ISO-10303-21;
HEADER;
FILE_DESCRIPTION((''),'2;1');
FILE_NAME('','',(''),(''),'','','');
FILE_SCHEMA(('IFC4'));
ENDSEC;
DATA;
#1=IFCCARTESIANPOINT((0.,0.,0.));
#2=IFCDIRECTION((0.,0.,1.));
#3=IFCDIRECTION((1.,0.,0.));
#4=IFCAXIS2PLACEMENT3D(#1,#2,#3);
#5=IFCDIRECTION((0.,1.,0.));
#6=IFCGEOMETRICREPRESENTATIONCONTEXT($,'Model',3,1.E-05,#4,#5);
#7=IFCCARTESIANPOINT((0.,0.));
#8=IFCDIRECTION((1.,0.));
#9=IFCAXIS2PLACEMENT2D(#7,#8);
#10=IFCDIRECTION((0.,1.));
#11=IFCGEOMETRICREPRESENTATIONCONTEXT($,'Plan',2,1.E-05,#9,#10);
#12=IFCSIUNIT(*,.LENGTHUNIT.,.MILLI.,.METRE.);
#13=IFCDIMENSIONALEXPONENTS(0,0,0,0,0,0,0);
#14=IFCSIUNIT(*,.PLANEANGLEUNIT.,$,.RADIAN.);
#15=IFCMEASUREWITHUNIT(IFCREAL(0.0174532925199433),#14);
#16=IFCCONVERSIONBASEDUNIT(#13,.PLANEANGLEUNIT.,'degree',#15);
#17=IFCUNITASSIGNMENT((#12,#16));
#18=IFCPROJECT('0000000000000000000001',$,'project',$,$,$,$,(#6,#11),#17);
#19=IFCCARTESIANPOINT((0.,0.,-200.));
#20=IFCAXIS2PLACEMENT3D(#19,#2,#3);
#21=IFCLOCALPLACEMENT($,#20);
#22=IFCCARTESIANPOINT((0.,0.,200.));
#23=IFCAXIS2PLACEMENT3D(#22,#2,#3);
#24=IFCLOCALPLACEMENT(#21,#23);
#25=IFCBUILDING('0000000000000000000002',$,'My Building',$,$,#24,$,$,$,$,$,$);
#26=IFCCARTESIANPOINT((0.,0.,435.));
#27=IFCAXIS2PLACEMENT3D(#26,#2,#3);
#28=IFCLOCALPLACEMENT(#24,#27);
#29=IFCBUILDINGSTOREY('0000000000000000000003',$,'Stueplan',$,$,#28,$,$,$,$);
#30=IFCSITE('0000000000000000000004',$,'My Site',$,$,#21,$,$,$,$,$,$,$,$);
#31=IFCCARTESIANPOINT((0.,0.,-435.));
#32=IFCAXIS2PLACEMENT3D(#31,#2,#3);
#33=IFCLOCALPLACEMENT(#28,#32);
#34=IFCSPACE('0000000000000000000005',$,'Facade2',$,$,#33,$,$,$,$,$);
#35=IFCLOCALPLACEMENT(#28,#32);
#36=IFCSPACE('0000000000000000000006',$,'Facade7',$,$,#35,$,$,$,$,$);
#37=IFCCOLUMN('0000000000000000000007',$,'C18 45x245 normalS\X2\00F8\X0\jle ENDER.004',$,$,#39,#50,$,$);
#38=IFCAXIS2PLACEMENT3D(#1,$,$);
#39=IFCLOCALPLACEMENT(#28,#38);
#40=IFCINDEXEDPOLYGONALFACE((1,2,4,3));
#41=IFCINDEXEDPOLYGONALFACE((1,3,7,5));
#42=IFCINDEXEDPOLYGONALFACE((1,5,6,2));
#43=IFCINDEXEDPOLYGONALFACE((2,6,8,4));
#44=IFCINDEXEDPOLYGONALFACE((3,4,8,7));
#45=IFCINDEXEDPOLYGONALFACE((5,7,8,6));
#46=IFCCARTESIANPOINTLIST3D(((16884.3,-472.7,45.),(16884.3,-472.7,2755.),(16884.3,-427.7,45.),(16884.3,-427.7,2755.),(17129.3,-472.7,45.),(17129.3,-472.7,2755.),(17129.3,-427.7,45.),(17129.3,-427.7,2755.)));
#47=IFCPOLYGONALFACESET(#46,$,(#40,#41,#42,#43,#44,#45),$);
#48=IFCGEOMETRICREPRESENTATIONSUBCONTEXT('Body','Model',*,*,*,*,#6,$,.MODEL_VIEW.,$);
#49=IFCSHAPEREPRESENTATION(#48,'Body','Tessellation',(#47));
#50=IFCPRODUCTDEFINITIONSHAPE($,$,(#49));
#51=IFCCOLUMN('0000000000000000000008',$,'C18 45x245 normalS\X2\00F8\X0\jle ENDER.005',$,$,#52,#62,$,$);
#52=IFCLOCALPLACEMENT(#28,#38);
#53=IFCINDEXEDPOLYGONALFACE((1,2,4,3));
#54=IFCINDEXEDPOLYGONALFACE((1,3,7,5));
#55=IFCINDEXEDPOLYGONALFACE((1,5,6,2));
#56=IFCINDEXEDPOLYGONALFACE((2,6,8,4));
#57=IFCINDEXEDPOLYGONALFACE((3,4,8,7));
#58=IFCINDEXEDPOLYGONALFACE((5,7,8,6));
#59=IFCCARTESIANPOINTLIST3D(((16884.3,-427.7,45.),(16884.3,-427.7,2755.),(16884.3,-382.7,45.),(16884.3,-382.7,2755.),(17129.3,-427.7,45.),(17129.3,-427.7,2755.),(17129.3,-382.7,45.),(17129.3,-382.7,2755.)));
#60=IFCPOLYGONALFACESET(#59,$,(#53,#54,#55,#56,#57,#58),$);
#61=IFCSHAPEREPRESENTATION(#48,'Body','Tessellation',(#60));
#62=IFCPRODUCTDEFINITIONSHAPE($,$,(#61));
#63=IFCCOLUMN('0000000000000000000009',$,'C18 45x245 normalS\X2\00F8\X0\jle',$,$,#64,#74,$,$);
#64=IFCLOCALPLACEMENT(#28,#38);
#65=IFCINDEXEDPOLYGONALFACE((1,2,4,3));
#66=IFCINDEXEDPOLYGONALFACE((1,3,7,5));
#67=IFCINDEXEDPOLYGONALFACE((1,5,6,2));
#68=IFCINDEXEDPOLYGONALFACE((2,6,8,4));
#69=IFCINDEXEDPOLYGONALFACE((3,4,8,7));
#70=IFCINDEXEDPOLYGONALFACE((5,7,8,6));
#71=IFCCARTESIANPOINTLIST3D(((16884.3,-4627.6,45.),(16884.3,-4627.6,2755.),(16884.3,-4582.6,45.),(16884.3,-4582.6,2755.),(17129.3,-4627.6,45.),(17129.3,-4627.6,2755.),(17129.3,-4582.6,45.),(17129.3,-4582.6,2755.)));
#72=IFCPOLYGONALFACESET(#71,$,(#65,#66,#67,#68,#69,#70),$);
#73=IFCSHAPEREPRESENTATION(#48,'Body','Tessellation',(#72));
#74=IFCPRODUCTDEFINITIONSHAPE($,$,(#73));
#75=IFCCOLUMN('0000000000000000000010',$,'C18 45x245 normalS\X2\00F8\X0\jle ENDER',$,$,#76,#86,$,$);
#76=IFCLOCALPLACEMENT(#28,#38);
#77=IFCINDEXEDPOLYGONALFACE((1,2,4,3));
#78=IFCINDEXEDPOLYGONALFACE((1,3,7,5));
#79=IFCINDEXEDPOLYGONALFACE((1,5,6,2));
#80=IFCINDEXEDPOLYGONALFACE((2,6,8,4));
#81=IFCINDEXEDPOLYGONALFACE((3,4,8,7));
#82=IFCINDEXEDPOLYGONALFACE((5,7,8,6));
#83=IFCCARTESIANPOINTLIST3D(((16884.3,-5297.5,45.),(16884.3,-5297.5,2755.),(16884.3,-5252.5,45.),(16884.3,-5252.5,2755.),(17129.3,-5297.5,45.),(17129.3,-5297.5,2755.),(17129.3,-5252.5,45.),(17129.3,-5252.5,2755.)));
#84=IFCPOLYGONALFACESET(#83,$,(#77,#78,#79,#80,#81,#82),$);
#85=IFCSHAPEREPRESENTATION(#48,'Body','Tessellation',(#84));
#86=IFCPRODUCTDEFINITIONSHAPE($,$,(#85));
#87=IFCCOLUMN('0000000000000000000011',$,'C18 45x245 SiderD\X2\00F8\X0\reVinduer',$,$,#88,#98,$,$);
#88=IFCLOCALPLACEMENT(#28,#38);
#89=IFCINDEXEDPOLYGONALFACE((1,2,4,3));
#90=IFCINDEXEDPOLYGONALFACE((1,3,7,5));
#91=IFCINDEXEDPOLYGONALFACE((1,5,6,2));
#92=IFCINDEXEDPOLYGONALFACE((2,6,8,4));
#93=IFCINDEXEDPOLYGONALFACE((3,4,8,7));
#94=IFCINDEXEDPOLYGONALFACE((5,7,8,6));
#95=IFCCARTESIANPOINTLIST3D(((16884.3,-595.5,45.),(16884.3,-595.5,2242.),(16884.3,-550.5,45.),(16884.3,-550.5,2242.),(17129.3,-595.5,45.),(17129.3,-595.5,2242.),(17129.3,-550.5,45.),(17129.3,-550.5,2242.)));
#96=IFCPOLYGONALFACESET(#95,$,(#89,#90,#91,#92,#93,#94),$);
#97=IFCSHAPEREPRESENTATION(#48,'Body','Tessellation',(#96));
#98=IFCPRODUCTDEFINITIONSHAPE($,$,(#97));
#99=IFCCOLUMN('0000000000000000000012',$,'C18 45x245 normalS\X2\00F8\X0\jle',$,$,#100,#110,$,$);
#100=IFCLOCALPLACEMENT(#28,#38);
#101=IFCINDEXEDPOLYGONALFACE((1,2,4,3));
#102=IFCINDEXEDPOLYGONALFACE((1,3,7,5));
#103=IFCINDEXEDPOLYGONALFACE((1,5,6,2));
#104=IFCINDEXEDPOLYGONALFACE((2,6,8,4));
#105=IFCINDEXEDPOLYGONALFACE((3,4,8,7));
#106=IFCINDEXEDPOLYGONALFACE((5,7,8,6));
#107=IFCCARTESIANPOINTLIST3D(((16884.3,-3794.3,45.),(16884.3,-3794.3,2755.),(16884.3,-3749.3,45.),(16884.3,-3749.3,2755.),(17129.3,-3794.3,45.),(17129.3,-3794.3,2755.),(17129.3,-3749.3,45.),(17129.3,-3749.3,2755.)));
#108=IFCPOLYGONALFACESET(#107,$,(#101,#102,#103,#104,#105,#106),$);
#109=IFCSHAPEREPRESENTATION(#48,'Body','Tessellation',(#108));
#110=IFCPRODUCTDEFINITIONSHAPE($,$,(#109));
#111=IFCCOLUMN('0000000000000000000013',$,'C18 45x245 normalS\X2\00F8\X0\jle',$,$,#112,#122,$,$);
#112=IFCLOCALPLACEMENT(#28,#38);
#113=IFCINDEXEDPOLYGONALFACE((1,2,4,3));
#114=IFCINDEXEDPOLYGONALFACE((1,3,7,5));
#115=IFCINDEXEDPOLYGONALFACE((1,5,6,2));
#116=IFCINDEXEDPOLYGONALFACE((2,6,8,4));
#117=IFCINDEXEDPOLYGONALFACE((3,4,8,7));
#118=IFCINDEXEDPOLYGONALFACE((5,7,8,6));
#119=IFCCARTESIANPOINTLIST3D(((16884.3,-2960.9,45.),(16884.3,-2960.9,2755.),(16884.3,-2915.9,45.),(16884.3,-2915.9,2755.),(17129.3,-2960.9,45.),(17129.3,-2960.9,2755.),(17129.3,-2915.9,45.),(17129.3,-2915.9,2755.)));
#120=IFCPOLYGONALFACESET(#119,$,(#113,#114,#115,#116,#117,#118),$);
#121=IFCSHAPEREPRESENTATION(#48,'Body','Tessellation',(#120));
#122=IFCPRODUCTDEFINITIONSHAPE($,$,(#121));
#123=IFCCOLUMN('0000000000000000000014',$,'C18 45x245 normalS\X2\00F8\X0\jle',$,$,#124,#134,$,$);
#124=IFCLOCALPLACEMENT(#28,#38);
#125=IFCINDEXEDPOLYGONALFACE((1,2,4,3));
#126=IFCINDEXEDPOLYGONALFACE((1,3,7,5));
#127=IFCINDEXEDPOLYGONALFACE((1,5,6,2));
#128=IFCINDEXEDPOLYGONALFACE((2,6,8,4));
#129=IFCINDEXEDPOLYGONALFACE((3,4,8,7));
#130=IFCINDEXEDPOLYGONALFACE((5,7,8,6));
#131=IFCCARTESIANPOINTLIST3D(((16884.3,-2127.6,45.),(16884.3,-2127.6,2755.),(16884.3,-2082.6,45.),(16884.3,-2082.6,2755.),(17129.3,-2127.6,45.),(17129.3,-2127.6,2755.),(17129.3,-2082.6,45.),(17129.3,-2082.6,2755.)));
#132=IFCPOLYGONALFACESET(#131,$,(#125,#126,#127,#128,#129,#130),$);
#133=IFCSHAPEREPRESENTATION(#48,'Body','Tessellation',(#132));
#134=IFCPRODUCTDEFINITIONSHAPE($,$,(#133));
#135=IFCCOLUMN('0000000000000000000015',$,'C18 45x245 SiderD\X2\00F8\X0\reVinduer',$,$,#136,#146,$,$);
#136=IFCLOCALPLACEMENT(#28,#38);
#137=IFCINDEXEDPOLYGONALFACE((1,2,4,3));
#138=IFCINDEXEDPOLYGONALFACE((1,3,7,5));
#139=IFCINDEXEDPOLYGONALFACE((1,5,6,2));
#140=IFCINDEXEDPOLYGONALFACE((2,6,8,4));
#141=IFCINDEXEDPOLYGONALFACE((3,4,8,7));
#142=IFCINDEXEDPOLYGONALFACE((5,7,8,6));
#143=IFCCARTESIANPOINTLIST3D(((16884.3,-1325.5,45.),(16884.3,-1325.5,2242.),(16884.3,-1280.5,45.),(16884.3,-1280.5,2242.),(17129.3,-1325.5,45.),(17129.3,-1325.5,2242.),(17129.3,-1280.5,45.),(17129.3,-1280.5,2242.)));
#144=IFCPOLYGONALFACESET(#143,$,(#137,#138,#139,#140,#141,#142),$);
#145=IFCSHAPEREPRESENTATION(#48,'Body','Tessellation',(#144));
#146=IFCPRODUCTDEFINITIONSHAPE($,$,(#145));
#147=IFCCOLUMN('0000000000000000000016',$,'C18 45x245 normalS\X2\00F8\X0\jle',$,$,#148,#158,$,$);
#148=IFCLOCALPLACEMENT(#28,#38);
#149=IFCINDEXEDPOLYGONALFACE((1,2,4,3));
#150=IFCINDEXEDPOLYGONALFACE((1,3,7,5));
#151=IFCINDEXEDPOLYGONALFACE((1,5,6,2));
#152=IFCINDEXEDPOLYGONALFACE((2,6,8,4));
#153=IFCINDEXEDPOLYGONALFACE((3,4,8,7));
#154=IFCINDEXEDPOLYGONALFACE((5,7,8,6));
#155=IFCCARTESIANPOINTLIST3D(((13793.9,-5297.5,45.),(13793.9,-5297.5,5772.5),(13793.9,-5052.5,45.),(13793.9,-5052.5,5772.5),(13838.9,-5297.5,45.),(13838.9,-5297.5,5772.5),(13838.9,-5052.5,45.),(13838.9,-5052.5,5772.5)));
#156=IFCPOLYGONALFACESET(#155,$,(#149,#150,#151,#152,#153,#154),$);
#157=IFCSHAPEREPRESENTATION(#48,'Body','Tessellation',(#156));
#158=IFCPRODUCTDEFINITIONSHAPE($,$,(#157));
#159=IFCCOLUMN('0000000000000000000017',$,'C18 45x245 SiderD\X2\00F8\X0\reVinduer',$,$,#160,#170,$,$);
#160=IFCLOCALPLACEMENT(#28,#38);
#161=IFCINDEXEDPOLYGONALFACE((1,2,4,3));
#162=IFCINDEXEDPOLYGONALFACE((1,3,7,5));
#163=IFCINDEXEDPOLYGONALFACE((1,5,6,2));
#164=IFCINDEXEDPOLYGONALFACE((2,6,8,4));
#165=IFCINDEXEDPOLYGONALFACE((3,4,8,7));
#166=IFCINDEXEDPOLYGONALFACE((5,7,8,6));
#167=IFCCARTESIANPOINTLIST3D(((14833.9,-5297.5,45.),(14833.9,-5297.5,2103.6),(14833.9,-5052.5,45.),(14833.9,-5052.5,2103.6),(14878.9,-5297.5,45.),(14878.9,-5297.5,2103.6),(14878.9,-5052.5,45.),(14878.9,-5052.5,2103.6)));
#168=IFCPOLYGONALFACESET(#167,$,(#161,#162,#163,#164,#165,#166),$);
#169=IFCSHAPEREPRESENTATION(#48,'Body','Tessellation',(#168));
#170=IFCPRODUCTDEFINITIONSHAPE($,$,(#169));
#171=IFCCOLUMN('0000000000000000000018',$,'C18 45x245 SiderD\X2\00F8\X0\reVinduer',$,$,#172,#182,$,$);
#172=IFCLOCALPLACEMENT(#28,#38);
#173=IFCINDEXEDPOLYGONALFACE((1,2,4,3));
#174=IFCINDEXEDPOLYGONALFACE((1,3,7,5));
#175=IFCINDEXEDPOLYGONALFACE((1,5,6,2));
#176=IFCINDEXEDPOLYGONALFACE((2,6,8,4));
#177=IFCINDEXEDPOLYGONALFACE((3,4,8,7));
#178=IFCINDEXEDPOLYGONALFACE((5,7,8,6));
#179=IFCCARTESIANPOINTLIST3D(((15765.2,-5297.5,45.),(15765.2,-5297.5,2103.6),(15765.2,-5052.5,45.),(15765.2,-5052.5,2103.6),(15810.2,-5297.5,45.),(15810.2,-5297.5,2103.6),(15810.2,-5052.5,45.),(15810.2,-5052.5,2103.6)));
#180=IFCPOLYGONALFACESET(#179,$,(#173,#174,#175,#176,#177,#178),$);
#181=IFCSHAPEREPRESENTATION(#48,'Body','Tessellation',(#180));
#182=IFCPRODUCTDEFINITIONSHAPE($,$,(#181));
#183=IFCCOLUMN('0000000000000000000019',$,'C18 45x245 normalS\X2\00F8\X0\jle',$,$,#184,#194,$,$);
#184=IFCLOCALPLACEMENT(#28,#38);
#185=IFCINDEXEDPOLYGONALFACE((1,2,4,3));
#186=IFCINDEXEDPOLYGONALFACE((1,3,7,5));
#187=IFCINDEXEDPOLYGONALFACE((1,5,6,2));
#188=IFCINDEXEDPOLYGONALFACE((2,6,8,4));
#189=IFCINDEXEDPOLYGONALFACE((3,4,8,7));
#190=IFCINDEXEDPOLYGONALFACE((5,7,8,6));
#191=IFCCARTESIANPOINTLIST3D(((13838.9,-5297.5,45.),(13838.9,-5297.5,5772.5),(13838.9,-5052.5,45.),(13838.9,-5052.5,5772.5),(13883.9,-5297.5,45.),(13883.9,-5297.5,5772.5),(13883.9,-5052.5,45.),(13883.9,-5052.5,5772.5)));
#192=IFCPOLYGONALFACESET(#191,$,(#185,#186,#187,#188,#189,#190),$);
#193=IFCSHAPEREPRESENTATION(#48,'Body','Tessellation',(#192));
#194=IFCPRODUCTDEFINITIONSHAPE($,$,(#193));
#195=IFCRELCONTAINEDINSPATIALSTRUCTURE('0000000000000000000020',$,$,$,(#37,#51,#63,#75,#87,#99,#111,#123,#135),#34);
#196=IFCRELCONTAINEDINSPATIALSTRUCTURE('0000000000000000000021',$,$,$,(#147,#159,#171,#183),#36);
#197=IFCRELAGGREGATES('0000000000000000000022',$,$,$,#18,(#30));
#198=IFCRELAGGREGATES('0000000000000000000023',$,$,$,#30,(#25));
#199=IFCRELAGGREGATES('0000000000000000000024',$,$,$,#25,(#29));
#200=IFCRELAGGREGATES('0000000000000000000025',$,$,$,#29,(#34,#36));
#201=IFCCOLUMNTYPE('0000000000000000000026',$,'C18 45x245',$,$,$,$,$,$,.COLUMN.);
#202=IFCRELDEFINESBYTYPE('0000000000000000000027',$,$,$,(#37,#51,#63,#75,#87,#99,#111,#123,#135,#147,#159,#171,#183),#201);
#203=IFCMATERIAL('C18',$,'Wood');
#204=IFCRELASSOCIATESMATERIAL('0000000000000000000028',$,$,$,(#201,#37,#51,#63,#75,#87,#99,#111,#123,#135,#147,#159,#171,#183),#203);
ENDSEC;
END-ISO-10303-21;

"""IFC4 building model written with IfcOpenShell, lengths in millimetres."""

from ifc_helpers import new_model, entity, si_unit, converted_unit, direction, frame, origin_with_axes, origin_2d_with_axis, place, context, subcontext, project, spatial, rectangle, extrude, material, material_profile, profile_set, profile_usage, type_object, element, save


model = new_model("IFC4")

# Units and contexts
model_context = context("Model", 3, precision=1e-05, world=origin_with_axes(), true_north=direction((0.0, 1.0, 0.0)))
plan_context = context("Plan", 2, precision=1e-05, world=origin_2d_with_axis(), true_north=direction((0.0, 1.0)))
body_context_1 = subcontext(model_context, "Body", "Model", "MODEL_VIEW")
ifc_project = project(units=[si_unit("LENGTHUNIT", "METRE", prefix="MILLI"), converted_unit("PLANEANGLEUNIT", "degree", entity("IfcReal", 0.0174532925199433), si_unit("PLANEANGLEUNIT", "RADIAN"), dimensions=[0, 0, 0, 0, 0, 0, 0])], contexts=[model_context, plan_context])

# Site, building, storey, space
site_placement = place(None, frame((0.0, 0.0, -200.0), z_axis=(0.0, 0.0, 1.0), x_axis=(1.0, 0.0, 0.0)))
site = spatial("IfcSite", under=ifc_project, at=site_placement, Name="My Site")
building_placement = place(site_placement, frame((0.0, 0.0, 200.0), z_axis=(0.0, 0.0, 1.0), x_axis=(1.0, 0.0, 0.0)))
building = spatial("IfcBuilding", under=site, at=building_placement, Name="My Building")
storey_placement = place(building_placement, frame((0.0, 0.0, 435.0), z_axis=(0.0, 0.0, 1.0), x_axis=(1.0, 0.0, 0.0)))
storey = spatial("IfcBuildingStorey", under=building, at=storey_placement, Name="Stueplan")
space_1_placement = place(storey_placement, frame((0.0, 0.0, -435.0), z_axis=(0.0, 0.0, 1.0), x_axis=(1.0, 0.0, 0.0)))
space_1 = spatial("IfcSpace", under=storey, at=space_1_placement, Name="Facade2")

# Columns
ifc_material = material(Name="C18", Category="Wood")
ifc_material_profile_1 = material_profile(ifc_material, rectangle(XDim=45.0, YDim=245.0))
ifc_profile_set_1 = profile_set([ifc_material_profile_1], Name="woodStructural")
ifc_profile_usage_1 = profile_usage(ifc_profile_set_1, cardinal=9)
column_type = type_object("IfcColumnType", Name="C18 45x245", PredefinedType="COLUMN", material=ifc_profile_set_1)
column_1_placement = place(space_1_placement, frame((17129.3, -427.7, 480.0), z_axis=(0.0, 0.0, 1.0), x_axis=(0.0, -1.0, 0.0)))
element("IfcColumn", 1, at=column_1_placement, inside=space_1, type_object=column_type, material=ifc_profile_usage_1, Name="C18 45x245 normalSøjle ENDER.004", context=body_context_1, shape_type="SweptSolid", body=[
    extrude(rectangle(XDim=45.0, YDim=245.0), frame((22.5, -122.5, 0.0), z_axis=(0.0, 0.0, 1.0), x_axis=(1.0, 0.0, 0.0)), (0.0, 0.0, 1.0), 2710.0),
])
ifc_profile_usage_2 = profile_usage(ifc_profile_set_1, cardinal=9)
column_2_placement = place(space_1_placement, frame((17129.3, -382.7, 480.0), z_axis=(0.0, 0.0, 1.0), x_axis=(0.0, -1.0, 0.0)))
element("IfcColumn", 2, at=column_2_placement, inside=space_1, type_object=column_type, material=ifc_profile_usage_2, Name="C18 45x245 normalSøjle ENDER.005", context=body_context_1, shape_type="SweptSolid", body=[
    extrude(rectangle(XDim=45.0, YDim=245.0), frame((22.5, -122.5, 0.0), z_axis=(0.0, 0.0, 1.0), x_axis=(1.0, 0.0, 0.0)), (0.0, 0.0, 1.0), 2710.0),
])
ifc_profile_usage_3 = profile_usage(ifc_profile_set_1, cardinal=9)
column_3_placement = place(space_1_placement, frame((17129.3, -4582.6, 480.0), z_axis=(0.0, 0.0, 1.0), x_axis=(0.0, -1.0, 0.0)))
element("IfcColumn", 3, at=column_3_placement, inside=space_1, type_object=column_type, material=ifc_profile_usage_3, Name="C18 45x245 normalSøjle", context=body_context_1, shape_type="SweptSolid", body=[
    extrude(rectangle(XDim=45.0, YDim=245.0), frame((22.5, -122.5, 0.0), z_axis=(0.0, 0.0, 1.0), x_axis=(1.0, 0.0, 0.0)), (0.0, 0.0, 1.0), 2710.0),
])
ifc_profile_usage_4 = profile_usage(ifc_profile_set_1, cardinal=9)
column_4_placement = place(space_1_placement, frame((17129.3, -5252.5, 480.0), z_axis=(0.0, 0.0, 1.0), x_axis=(0.0, -1.0, 0.0)))
element("IfcColumn", 4, at=column_4_placement, inside=space_1, type_object=column_type, material=ifc_profile_usage_4, Name="C18 45x245 normalSøjle ENDER", context=body_context_1, shape_type="SweptSolid", body=[
    extrude(rectangle(XDim=45.0, YDim=245.0), frame((22.5, -122.5, 0.0), z_axis=(0.0, 0.0, 1.0), x_axis=(1.0, 0.0, 0.0)), (0.0, 0.0, 1.0), 2710.0),
])
ifc_profile_usage_5 = profile_usage(ifc_profile_set_1, cardinal=9)
column_5_placement = place(space_1_placement, frame((17129.3, -550.5, 480.0), z_axis=(0.0, 0.0, 1.0), x_axis=(0.0, -1.0, 0.0)))
element("IfcColumn", 5, at=column_5_placement, inside=space_1, type_object=column_type, material=ifc_profile_usage_5, Name="C18 45x245 SiderDøreVinduer", context=body_context_1, shape_type="SweptSolid", body=[
    extrude(rectangle(XDim=45.0, YDim=245.0), frame((22.5, -122.5, 0.0), z_axis=(0.0, 0.0, 1.0), x_axis=(1.0, 0.0, 0.0)), (0.0, 0.0, 1.0), 2197.0),
])
ifc_profile_usage_6 = profile_usage(ifc_profile_set_1, cardinal=9)
column_6_placement = place(space_1_placement, frame((17129.3, -3749.3, 480.0), z_axis=(0.0, 0.0, 1.0), x_axis=(0.0, -1.0, 0.0)))
element("IfcColumn", 6, at=column_6_placement, inside=space_1, type_object=column_type, material=ifc_profile_usage_6, Name="C18 45x245 normalSøjle", context=body_context_1, shape_type="SweptSolid", body=[
    extrude(rectangle(XDim=45.0, YDim=245.0), frame((22.5, -122.5, 0.0), z_axis=(0.0, 0.0, 1.0), x_axis=(1.0, 0.0, 0.0)), (0.0, 0.0, 1.0), 2710.0),
])
ifc_profile_usage_7 = profile_usage(ifc_profile_set_1, cardinal=9)
column_7_placement = place(space_1_placement, frame((17129.3, -2915.9, 480.0), z_axis=(0.0, 0.0, 1.0), x_axis=(0.0, -1.0, 0.0)))
element("IfcColumn", 7, at=column_7_placement, inside=space_1, type_object=column_type, material=ifc_profile_usage_7, Name="C18 45x245 normalSøjle", context=body_context_1, shape_type="SweptSolid", body=[
    extrude(rectangle(XDim=45.0, YDim=245.0), frame((22.5, -122.5, 0.0), z_axis=(0.0, 0.0, 1.0), x_axis=(1.0, 0.0, 0.0)), (0.0, 0.0, 1.0), 2710.0),
])
ifc_profile_usage_8 = profile_usage(ifc_profile_set_1, cardinal=9)
column_8_placement = place(space_1_placement, frame((17129.3, -2082.6, 480.0), z_axis=(0.0, 0.0, 1.0), x_axis=(0.0, -1.0, 0.0)))
element("IfcColumn", 8, at=column_8_placement, inside=space_1, type_object=column_type, material=ifc_profile_usage_8, Name="C18 45x245 normalSøjle", context=body_context_1, shape_type="SweptSolid", body=[
    extrude(rectangle(XDim=45.0, YDim=245.0), frame((22.5, -122.5, 0.0), z_axis=(0.0, 0.0, 1.0), x_axis=(1.0, 0.0, 0.0)), (0.0, 0.0, 1.0), 2710.0),
])
ifc_profile_usage_9 = profile_usage(ifc_profile_set_1, cardinal=9)
column_9_placement = place(space_1_placement, frame((17129.3, -1280.5, 480.0), z_axis=(0.0, 0.0, 1.0), x_axis=(0.0, -1.0, 0.0)))
element("IfcColumn", 9, at=column_9_placement, inside=space_1, type_object=column_type, material=ifc_profile_usage_9, Name="C18 45x245 SiderDøreVinduer", context=body_context_1, shape_type="SweptSolid", body=[
    extrude(rectangle(XDim=45.0, YDim=245.0), frame((22.5, -122.5, 0.0), z_axis=(0.0, 0.0, 1.0), x_axis=(1.0, 0.0, 0.0)), (0.0, 0.0, 1.0), 2197.0),
])

# Shared definitions
space_2_placement = place(storey_placement, frame((0.0, 0.0, -435.0), z_axis=(0.0, 0.0, 1.0), x_axis=(1.0, 0.0, 0.0)))
space_2 = spatial("IfcSpace", under=storey, at=space_2_placement, Name="Facade7")

# Columns
ifc_profile_usage_10 = profile_usage(ifc_profile_set_1, cardinal=9)
column_10_placement = place(space_2_placement, frame((13838.9, -5297.5, 480.0), z_axis=(0.0, 0.0, 1.0), x_axis=(-1.0, 0.0, 0.0)))
element("IfcColumn", 10, at=column_10_placement, inside=space_2, type_object=column_type, material=ifc_profile_usage_10, Name="C18 45x245 normalSøjle", context=body_context_1, shape_type="SweptSolid", body=[
    extrude(rectangle(XDim=45.0, YDim=245.0), frame((22.5, -122.5, 0.0), z_axis=(0.0, 0.0, 1.0), x_axis=(1.0, 0.0, 0.0)), (0.0, 0.0, 1.0), 5727.5),
])
ifc_profile_usage_11 = profile_usage(ifc_profile_set_1, cardinal=9)
column_11_placement = place(space_2_placement, frame((14878.9, -5297.5, 480.0), z_axis=(0.0, 0.0, 1.0), x_axis=(-1.0, 0.0, 0.0)))
element("IfcColumn", 11, at=column_11_placement, inside=space_2, type_object=column_type, material=ifc_profile_usage_11, Name="C18 45x245 SiderDøreVinduer", context=body_context_1, shape_type="SweptSolid", body=[
    extrude(rectangle(XDim=45.0, YDim=245.0), frame((22.5, -122.5, 0.0), z_axis=(0.0, 0.0, 1.0), x_axis=(1.0, 0.0, 0.0)), (0.0, 0.0, 1.0), 2058.6),
])
ifc_profile_usage_12 = profile_usage(ifc_profile_set_1, cardinal=9)
column_12_placement = place(space_2_placement, frame((15810.2, -5297.5, 480.0), z_axis=(0.0, 0.0, 1.0), x_axis=(-1.0, 0.0, 0.0)))
element("IfcColumn", 12, at=column_12_placement, inside=space_2, type_object=column_type, material=ifc_profile_usage_12, Name="C18 45x245 SiderDøreVinduer", context=body_context_1, shape_type="SweptSolid", body=[
    extrude(rectangle(XDim=45.0, YDim=245.0), frame((22.5, -122.5, 0.0), z_axis=(0.0, 0.0, 1.0), x_axis=(1.0, 0.0, 0.0)), (0.0, 0.0, 1.0), 2058.6),
])
ifc_profile_usage_13 = profile_usage(ifc_profile_set_1, cardinal=9)
column_13_placement = place(space_2_placement, frame((13883.9, -5297.5, 480.0), z_axis=(0.0, 0.0, 1.0), x_axis=(-1.0, 0.0, 0.0)))
element("IfcColumn", 13, at=column_13_placement, inside=space_2, type_object=column_type, material=ifc_profile_usage_13, Name="C18 45x245 normalSøjle", context=body_context_1, shape_type="SweptSolid", body=[
    extrude(rectangle(XDim=45.0, YDim=245.0), frame((22.5, -122.5, 0.0), z_axis=(0.0, 0.0, 1.0), x_axis=(1.0, 0.0, 0.0)), (0.0, 0.0, 1.0), 5727.5),
])

save(model, "model.ifc")
